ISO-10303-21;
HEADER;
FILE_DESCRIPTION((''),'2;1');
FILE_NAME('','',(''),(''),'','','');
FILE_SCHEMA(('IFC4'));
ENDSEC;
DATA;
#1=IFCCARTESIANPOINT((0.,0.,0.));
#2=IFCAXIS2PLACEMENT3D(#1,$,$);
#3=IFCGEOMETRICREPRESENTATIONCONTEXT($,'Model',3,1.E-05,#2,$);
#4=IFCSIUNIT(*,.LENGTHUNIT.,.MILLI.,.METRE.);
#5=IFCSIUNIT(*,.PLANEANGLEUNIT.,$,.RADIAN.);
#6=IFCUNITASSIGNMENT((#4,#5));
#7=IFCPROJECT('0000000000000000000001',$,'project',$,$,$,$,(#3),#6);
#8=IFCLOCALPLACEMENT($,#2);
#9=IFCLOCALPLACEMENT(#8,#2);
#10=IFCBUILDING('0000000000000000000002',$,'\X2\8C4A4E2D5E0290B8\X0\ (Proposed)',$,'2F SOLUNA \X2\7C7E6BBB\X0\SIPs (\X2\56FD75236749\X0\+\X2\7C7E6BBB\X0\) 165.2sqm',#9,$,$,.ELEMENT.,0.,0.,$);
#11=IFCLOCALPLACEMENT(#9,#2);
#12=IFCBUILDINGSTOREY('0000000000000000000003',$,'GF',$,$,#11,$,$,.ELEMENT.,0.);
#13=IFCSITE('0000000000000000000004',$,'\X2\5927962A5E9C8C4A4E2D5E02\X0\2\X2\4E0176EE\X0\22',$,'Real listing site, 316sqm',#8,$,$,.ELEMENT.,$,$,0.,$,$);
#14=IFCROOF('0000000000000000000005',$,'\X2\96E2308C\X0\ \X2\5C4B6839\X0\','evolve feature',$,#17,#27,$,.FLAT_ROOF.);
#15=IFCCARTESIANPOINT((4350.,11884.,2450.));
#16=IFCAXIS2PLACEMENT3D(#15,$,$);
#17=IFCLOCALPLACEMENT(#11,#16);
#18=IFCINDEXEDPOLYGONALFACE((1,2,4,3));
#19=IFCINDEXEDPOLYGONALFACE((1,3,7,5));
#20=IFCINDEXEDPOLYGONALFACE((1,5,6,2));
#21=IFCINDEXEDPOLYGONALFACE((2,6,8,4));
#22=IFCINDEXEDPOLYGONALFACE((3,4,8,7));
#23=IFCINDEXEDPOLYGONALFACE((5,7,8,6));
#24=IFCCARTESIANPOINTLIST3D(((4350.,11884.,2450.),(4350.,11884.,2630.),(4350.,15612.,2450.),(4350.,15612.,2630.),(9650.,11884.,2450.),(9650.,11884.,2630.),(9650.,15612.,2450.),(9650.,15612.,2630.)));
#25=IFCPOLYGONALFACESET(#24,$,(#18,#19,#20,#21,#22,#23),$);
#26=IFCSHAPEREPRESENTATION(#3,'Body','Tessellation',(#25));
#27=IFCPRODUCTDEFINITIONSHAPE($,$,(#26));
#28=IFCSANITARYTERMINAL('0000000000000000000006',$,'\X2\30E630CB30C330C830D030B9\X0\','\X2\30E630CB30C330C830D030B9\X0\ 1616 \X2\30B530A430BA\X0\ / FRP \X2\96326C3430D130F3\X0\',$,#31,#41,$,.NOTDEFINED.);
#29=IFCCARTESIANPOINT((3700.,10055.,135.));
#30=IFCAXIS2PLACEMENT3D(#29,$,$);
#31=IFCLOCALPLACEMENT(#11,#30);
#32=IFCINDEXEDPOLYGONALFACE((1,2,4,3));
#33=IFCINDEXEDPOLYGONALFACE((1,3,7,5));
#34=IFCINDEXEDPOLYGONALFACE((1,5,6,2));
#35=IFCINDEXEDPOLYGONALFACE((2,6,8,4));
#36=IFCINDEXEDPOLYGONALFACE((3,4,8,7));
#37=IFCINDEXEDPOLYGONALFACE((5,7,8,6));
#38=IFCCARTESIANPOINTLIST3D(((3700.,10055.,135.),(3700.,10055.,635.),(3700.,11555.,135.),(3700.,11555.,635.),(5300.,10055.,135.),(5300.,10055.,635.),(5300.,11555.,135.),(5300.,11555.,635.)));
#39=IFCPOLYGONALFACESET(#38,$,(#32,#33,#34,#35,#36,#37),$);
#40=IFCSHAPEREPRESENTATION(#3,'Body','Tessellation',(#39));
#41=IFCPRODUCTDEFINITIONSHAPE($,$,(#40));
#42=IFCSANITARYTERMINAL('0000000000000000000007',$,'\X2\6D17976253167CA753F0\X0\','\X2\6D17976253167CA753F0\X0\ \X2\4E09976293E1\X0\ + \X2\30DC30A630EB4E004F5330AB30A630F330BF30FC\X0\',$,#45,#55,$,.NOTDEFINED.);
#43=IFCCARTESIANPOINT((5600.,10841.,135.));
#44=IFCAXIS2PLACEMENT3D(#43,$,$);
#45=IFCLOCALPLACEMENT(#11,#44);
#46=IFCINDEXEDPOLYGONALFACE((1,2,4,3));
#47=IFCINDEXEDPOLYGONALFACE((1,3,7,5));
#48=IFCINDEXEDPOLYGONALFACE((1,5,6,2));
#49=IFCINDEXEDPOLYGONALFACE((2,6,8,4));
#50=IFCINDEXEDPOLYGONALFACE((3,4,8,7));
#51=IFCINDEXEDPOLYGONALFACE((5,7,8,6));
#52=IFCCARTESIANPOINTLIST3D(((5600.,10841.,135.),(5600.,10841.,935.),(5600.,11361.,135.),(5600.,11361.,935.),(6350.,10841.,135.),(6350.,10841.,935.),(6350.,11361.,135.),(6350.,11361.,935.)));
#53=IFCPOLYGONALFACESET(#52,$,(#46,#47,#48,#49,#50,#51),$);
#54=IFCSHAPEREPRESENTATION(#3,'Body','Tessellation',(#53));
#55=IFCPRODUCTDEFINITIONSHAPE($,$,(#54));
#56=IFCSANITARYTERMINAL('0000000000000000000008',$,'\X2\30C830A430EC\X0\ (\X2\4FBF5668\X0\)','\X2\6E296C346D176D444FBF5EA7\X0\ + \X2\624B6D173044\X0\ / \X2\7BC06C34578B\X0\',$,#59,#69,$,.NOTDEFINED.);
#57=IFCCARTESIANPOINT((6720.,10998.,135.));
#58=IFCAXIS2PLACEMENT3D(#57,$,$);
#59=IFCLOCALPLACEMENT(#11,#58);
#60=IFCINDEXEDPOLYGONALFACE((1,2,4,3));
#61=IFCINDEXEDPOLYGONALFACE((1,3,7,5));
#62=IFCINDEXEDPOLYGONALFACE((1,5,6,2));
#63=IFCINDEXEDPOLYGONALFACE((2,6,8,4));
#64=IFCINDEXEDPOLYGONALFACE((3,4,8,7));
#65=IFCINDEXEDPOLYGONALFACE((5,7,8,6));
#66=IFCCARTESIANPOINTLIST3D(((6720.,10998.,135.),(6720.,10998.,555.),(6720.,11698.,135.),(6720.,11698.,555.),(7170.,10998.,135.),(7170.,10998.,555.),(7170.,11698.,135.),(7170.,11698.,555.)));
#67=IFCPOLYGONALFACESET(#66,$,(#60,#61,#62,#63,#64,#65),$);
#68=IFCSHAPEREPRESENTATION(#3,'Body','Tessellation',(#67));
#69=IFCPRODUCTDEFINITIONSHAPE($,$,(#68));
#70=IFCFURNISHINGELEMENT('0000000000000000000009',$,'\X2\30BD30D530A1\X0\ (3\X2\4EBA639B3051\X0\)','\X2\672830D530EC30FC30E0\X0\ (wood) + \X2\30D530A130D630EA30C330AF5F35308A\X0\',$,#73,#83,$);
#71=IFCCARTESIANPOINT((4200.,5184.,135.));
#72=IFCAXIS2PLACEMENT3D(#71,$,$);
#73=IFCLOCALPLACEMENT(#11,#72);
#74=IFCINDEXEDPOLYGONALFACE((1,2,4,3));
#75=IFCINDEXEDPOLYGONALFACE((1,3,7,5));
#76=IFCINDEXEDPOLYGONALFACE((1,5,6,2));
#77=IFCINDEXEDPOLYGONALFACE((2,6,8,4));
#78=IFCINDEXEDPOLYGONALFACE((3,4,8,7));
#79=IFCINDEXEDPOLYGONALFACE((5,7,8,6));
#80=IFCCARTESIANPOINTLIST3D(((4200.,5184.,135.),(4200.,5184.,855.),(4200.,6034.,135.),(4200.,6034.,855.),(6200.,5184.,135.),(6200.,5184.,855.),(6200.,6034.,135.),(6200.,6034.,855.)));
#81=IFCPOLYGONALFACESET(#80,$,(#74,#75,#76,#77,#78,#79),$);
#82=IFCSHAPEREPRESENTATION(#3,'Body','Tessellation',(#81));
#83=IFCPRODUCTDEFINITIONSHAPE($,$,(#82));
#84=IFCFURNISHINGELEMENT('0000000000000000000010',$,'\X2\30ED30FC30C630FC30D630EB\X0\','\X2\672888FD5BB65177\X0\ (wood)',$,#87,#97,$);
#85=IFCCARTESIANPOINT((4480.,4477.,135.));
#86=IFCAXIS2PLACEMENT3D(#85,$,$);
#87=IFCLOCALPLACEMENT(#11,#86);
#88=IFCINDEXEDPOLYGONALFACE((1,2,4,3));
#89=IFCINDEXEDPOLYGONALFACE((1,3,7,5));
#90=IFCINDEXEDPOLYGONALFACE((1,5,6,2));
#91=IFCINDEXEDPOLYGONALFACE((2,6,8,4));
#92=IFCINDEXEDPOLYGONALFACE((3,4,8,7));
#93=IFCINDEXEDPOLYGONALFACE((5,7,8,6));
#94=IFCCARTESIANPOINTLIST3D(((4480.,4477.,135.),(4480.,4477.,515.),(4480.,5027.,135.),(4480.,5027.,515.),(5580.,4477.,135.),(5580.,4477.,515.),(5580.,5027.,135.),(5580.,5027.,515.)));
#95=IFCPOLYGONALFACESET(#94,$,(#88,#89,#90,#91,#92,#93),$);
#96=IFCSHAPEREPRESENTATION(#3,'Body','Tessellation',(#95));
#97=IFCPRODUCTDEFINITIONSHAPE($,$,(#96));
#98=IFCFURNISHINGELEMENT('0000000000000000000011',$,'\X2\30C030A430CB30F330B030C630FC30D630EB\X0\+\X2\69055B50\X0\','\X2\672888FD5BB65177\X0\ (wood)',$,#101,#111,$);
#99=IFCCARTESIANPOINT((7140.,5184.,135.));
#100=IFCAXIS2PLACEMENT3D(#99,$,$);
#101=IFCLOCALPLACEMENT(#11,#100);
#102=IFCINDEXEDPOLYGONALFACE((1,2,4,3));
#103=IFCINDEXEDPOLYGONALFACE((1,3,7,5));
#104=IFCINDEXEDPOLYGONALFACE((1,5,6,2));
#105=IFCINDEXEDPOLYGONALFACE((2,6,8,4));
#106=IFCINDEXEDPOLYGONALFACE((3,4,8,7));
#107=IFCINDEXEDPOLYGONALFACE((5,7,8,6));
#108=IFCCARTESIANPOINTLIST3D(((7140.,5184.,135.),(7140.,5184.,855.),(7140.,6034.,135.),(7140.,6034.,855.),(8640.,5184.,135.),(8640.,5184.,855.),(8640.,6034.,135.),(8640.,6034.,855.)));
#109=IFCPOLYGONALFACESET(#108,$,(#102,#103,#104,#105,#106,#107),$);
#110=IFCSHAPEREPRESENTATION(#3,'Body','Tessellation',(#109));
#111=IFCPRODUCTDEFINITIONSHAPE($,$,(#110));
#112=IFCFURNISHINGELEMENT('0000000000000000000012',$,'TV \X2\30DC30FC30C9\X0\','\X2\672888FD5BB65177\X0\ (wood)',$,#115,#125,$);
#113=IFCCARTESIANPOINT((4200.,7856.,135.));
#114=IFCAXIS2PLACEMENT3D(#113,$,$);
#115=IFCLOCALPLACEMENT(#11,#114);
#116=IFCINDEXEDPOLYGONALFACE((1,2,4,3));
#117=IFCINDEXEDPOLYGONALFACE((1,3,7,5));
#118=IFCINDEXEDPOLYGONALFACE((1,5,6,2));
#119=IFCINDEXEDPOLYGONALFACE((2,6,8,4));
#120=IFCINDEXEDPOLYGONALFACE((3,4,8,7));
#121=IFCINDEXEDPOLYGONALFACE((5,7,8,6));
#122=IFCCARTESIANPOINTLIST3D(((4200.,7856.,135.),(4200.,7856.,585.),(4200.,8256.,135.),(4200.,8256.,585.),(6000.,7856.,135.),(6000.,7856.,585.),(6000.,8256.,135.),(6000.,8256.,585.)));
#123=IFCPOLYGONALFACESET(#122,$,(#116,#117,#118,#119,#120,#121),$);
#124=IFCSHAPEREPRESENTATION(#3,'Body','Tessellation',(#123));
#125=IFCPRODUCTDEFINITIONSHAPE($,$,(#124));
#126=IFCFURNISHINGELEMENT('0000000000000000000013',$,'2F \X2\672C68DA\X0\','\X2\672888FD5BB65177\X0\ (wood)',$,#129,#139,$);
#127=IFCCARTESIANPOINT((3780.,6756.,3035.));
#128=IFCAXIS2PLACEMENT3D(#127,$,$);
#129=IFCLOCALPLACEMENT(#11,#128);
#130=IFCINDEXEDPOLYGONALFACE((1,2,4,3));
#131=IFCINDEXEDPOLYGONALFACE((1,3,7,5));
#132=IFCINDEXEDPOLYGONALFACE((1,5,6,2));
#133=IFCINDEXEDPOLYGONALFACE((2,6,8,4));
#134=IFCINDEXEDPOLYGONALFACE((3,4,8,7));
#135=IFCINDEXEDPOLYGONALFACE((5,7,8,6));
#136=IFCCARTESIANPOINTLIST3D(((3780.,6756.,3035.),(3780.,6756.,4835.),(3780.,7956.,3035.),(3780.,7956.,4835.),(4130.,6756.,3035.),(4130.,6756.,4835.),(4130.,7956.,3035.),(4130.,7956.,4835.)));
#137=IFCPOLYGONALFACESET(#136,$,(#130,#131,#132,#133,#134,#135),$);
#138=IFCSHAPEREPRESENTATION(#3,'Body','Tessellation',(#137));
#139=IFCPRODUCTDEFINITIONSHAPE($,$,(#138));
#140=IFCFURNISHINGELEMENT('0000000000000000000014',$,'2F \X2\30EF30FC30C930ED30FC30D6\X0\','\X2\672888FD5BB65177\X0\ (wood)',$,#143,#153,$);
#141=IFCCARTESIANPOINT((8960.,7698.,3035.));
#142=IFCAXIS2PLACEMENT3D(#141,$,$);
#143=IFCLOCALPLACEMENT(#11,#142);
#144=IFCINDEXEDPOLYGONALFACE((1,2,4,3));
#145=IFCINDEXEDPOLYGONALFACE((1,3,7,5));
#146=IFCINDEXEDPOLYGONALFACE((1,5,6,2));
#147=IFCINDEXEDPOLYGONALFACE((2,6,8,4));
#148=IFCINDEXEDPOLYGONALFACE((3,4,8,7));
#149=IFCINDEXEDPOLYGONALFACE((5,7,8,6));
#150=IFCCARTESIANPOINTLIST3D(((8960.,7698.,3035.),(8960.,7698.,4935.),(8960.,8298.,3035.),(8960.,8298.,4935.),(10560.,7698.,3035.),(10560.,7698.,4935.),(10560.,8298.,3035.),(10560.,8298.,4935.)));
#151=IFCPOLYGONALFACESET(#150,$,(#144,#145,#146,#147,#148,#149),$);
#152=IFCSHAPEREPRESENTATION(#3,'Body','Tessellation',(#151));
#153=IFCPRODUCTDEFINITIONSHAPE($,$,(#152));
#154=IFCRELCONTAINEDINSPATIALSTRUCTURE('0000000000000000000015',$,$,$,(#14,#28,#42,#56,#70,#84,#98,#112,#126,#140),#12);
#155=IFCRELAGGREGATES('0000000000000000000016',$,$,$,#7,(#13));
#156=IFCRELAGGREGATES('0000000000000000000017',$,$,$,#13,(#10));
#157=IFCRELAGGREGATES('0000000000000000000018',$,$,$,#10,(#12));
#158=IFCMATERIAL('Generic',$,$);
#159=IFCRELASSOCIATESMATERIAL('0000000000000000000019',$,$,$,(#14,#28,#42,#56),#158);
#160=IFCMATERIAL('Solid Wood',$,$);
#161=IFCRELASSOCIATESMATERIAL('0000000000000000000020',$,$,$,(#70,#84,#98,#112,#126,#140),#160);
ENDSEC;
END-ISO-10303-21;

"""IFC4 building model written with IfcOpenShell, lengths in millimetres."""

from ifc_helpers import new_model, si_unit, frame, frame_2d, origin, place, context, project, spatial, rectangle, extrude, material, element, save


model = new_model("IFC4")

# Units and contexts
model_context = context("Model", 3, precision=1e-05, world=origin())
ifc_project = project(units=[si_unit("LENGTHUNIT", "METRE", prefix="MILLI"), si_unit("PLANEANGLEUNIT", "RADIAN")], contexts=[model_context])

# Site, building, storey
site_placement = place(None, origin())
site = spatial("IfcSite", under=ifc_project, at=site_placement, Name="大阪府豊中市2丁目22", ObjectType="Real listing site, 316sqm", CompositionType="ELEMENT", RefElevation=0.0)
building_placement = place(site_placement, origin())
building = spatial("IfcBuilding", under=site, at=building_placement, Name="豊中市邸 (Proposed)", ObjectType="2F SOLUNA 籾殻SIPs (国産杉+籾殻) 165.2sqm", CompositionType="ELEMENT", ElevationOfRefHeight=0.0, ElevationOfTerrain=0.0)
storey_placement = place(building_placement, origin())
storey = spatial("IfcBuildingStorey", under=building, at=storey_placement, Name="GF", CompositionType="ELEMENT", Elevation=0.0)

# Shared definitions
ifc_material_1 = material(Name="Generic")

# Shared definitions
ifc_material_2 = material(Name="Solid Wood")

# Roof
roof_placement = place(storey_placement, frame((4350.0, 11884.0, 2450.0)))
element("IfcRoof", 1, at=roof_placement, inside=storey, material=ifc_material_1, Name="離れ 屋根", Description="evolve feature", PredefinedType="FLAT_ROOF", context=model_context, shape_type="SweptSolid", body=[
    extrude(rectangle(XDim=5300.0, YDim=3728.0, at=frame_2d((2650.0, 1864.0))), frame((4350.0, 11884.0, 2450.0)), (0.0, 0.0, 1.0), 180.0),
])

# Sanitary terminals
sanitary_terminal_1_placement = place(storey_placement, frame((3700.0, 10055.0, 135.0)))
element("IfcSanitaryTerminal", 2, at=sanitary_terminal_1_placement, inside=storey, material=ifc_material_1, Name="ユニットバス", Description="ユニットバス 1616 サイズ / FRP 防水パン", PredefinedType="NOTDEFINED", context=model_context, shape_type="SweptSolid", body=[
    extrude(rectangle(XDim=1600.0, YDim=1500.0, at=frame_2d((800.0, 750.0))), frame((3700.0, 10055.0, 135.0)), (0.0, 0.0, 1.0), 500.0),
])
sanitary_terminal_2_placement = place(storey_placement, frame((5600.0, 10841.0, 135.0)))
element("IfcSanitaryTerminal", 3, at=sanitary_terminal_2_placement, inside=storey, material=ifc_material_1, Name="洗面化粧台", Description="洗面化粧台 三面鏡 + ボウル一体カウンター", PredefinedType="NOTDEFINED", context=model_context, shape_type="SweptSolid", body=[
    extrude(rectangle(XDim=750.0, YDim=520.0, at=frame_2d((375.0, 260.0))), frame((5600.0, 10841.0, 135.0)), (0.0, 0.0, 1.0), 800.0),
])
sanitary_terminal_3_placement = place(storey_placement, frame((6720.0, 10998.0, 135.0)))
element("IfcSanitaryTerminal", 4, at=sanitary_terminal_3_placement, inside=storey, material=ifc_material_1, Name="トイレ (便器)", Description="温水洗浄便座 + 手洗い / 節水型", PredefinedType="NOTDEFINED", context=model_context, shape_type="SweptSolid", body=[
    extrude(rectangle(XDim=450.0, YDim=700.0, at=frame_2d((225.0, 350.0))), frame((6720.0, 10998.0, 135.0)), (0.0, 0.0, 1.0), 420.0),
])

# Furnishing elements
furnishing_1_placement = place(storey_placement, frame((4200.0, 5184.0, 135.0)))
element("IfcFurnishingElement", 5, at=furnishing_1_placement, inside=storey, material=ifc_material_2, Name="ソファ (3人掛け)", Description="木フレーム (wood) + ファブリック張り", context=model_context, shape_type="SweptSolid", body=[
    extrude(rectangle(XDim=2000.0, YDim=850.0, at=frame_2d((1000.0, 425.0))), frame((4200.0, 5184.0, 135.0)), (0.0, 0.0, 1.0), 720.0),
])
furnishing_2_placement = place(storey_placement, frame((4480.0, 4477.0, 135.0)))
element("IfcFurnishingElement", 6, at=furnishing_2_placement, inside=storey, material=ifc_material_2, Name="ローテーブル", Description="木製家具 (wood)", context=model_context, shape_type="SweptSolid", body=[
    extrude(rectangle(XDim=1100.0, YDim=550.0, at=frame_2d((550.0, 275.0))), frame((4480.0, 4477.0, 135.0)), (0.0, 0.0, 1.0), 380.0),
])
furnishing_3_placement = place(storey_placement, frame((7140.0, 5184.0, 135.0)))
element("IfcFurnishingElement", 7, at=furnishing_3_placement, inside=storey, material=ifc_material_2, Name="ダイニングテーブル+椅子", Description="木製家具 (wood)", context=model_context, shape_type="SweptSolid", body=[
    extrude(rectangle(XDim=1500.0, YDim=850.0, at=frame_2d((750.0, 425.0))), frame((7140.0, 5184.0, 135.0)), (0.0, 0.0, 1.0), 720.0),
])
furnishing_4_placement = place(storey_placement, frame((4200.0, 7856.0, 135.0)))
element("IfcFurnishingElement", 8, at=furnishing_4_placement, inside=storey, material=ifc_material_2, Name="TV ボード", Description="木製家具 (wood)", context=model_context, shape_type="SweptSolid", body=[
    extrude(rectangle(XDim=1800.0, YDim=400.0, at=frame_2d((900.0, 200.0))), frame((4200.0, 7856.0, 135.0)), (0.0, 0.0, 1.0), 450.0),
])
furnishing_5_placement = place(storey_placement, frame((3780.0, 6756.0, 3035.0)))
element("IfcFurnishingElement", 9, at=furnishing_5_placement, inside=storey, material=ifc_material_2, Name="2F 本棚", Description="木製家具 (wood)", context=model_context, shape_type="SweptSolid", body=[
    extrude(rectangle(XDim=350.0, YDim=1200.0, at=frame_2d((175.0, 600.0))), frame((3780.0, 6756.0, 3035.0)), (0.0, 0.0, 1.0), 1800.0),
])
furnishing_6_placement = place(storey_placement, frame((8960.0, 7698.0, 3035.0)))
element("IfcFurnishingElement", 10, at=furnishing_6_placement, inside=storey, material=ifc_material_2, Name="2F ワードローブ", Description="木製家具 (wood)", context=model_context, shape_type="SweptSolid", body=[
    extrude(rectangle(XDim=1600.0, YDim=600.0, at=frame_2d((800.0, 300.0))), frame((8960.0, 7698.0, 3035.0)), (0.0, 0.0, 1.0), 1900.0),
])

save(model, "model.ifc")
